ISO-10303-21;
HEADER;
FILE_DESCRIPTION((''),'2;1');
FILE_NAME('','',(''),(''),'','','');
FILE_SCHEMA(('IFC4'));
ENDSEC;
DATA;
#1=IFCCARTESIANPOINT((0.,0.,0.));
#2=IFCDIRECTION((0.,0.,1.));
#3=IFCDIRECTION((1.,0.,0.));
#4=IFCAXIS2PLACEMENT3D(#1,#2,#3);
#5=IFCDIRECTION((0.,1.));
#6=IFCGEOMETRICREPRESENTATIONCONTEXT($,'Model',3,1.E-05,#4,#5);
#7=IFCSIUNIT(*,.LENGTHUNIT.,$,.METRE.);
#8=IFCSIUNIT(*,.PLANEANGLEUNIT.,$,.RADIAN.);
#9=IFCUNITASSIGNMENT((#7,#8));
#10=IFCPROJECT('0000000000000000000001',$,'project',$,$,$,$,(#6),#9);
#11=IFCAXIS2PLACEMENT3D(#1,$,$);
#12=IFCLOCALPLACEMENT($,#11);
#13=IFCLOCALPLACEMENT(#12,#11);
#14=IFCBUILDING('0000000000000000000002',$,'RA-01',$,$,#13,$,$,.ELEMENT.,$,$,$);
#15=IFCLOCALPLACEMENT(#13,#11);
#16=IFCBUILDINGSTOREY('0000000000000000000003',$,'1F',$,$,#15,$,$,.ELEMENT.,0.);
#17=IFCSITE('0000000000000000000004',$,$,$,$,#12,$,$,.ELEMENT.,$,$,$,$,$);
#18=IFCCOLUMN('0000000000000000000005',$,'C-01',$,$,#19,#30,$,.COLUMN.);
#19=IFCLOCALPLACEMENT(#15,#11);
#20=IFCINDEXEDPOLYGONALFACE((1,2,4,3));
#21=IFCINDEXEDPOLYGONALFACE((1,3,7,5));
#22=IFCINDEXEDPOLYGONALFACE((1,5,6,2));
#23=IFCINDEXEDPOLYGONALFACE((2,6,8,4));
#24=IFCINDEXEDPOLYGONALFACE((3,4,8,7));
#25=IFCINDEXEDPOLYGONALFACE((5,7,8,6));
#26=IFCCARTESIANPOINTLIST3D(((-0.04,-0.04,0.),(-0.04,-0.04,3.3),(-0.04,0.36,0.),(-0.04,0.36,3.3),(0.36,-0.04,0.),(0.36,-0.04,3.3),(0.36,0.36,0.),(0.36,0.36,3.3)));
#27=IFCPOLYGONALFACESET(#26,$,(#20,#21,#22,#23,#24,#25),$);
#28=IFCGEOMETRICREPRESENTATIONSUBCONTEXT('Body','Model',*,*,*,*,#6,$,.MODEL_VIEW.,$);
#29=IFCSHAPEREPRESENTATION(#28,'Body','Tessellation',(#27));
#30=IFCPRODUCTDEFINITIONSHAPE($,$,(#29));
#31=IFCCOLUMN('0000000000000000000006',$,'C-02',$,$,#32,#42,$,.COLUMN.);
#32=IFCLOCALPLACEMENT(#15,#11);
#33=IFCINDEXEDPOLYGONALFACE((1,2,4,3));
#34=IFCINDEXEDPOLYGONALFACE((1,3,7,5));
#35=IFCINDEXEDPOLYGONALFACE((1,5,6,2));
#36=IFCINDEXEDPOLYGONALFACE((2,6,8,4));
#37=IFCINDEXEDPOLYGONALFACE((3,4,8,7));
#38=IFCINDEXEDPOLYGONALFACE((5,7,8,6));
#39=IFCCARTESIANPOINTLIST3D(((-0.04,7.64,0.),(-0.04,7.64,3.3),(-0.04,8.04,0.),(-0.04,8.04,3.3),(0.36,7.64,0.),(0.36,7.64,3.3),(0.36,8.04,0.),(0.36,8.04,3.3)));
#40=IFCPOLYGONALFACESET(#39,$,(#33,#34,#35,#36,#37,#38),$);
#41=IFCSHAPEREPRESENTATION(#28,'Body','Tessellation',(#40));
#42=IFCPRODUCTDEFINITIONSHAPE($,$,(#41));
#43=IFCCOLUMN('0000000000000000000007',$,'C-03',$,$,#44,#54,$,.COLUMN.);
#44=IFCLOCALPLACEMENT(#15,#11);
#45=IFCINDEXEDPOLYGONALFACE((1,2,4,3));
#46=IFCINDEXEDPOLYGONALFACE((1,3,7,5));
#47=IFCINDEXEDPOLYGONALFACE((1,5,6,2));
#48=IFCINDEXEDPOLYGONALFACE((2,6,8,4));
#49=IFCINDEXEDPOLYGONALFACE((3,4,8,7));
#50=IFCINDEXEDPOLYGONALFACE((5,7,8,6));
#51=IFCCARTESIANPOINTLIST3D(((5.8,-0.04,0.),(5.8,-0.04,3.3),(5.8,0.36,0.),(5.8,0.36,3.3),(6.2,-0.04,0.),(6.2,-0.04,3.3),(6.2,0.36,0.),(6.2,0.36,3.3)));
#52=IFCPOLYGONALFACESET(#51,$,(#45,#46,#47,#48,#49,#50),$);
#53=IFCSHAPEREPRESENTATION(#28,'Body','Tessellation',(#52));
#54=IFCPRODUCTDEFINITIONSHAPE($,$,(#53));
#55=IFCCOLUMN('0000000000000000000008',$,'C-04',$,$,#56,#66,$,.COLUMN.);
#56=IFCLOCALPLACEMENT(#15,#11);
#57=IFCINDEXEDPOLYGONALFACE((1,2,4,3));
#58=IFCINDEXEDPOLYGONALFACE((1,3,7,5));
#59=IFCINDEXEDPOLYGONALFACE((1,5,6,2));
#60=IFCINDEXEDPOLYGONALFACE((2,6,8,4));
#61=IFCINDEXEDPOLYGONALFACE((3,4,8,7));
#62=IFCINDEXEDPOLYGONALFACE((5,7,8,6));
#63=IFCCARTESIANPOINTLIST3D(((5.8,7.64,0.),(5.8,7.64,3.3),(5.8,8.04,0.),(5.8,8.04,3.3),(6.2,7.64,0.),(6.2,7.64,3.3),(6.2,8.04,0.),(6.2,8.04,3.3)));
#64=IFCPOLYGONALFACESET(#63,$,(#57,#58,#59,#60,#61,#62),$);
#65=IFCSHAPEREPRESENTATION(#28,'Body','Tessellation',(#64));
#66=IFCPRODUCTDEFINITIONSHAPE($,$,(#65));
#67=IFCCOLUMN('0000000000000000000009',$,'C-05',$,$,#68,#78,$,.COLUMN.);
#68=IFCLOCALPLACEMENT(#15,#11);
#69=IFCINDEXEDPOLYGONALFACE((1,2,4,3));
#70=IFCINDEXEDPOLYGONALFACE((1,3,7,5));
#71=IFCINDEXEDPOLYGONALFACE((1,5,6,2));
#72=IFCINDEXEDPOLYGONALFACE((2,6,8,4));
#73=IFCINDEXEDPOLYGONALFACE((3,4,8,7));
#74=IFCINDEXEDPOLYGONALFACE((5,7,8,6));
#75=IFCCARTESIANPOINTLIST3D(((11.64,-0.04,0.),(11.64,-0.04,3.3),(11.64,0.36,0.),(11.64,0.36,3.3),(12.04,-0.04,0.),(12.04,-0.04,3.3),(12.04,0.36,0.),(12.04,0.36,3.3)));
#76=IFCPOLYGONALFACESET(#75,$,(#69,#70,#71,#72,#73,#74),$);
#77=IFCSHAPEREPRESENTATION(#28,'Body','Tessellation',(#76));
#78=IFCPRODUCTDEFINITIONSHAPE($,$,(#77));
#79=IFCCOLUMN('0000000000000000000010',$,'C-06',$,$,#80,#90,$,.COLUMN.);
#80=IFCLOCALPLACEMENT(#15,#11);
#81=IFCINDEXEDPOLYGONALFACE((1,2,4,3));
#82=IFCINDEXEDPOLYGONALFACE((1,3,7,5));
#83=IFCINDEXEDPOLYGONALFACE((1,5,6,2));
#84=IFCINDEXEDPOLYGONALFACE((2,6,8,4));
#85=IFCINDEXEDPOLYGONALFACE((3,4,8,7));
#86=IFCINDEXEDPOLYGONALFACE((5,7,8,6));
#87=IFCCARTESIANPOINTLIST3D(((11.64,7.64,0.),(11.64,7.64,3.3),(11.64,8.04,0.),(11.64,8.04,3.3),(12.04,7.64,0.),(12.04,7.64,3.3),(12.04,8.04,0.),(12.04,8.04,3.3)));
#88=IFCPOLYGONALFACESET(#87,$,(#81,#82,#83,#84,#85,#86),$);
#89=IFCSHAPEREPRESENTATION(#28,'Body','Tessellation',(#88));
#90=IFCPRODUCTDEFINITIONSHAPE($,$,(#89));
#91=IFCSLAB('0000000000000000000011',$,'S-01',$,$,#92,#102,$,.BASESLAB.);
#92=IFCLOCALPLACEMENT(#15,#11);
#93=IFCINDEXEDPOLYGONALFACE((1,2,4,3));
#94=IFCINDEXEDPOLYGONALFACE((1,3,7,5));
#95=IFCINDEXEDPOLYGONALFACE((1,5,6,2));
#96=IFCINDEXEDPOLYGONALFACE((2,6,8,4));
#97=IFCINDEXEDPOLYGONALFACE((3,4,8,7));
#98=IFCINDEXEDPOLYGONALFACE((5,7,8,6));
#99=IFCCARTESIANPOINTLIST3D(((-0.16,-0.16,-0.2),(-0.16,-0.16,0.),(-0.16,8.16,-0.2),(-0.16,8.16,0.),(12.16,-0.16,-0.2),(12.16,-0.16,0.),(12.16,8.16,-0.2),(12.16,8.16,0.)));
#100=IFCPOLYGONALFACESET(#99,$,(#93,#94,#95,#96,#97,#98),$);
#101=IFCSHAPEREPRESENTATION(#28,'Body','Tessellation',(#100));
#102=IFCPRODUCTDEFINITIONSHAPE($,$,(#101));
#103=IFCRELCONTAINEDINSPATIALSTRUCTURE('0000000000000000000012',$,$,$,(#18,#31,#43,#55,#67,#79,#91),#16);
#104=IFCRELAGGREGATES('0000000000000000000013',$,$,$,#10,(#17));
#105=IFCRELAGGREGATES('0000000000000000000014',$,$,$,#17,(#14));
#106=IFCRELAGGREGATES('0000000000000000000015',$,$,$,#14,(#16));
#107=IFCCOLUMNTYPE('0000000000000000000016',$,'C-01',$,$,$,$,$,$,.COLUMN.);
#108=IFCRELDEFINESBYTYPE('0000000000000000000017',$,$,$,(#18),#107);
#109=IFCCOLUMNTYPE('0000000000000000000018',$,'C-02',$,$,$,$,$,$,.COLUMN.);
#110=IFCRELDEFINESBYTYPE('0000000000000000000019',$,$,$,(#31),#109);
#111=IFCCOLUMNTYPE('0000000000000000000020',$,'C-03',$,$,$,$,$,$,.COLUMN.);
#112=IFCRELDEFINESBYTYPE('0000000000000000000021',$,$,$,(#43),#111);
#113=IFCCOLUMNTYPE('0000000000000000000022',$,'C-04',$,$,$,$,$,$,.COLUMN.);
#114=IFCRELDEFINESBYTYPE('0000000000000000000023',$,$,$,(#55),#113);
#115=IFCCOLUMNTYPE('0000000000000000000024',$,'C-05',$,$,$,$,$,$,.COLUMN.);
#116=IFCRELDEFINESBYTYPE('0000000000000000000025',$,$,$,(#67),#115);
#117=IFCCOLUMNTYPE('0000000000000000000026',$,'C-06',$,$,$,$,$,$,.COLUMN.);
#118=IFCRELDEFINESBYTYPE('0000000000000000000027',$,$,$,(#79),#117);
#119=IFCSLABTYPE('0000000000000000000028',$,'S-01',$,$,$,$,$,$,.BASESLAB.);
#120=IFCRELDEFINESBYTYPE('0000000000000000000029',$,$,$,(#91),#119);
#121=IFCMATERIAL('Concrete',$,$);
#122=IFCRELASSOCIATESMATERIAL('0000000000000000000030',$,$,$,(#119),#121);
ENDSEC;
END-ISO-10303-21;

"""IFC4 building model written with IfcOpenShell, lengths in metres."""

from ifc_helpers import new_model, si_unit, direction, frame, origin, origin_with_axes, origin_2d, place, context, subcontext, project, spatial, polyline, rectangle, outline, extrude, material, type_object, element, save


model = new_model("IFC4")

# Units and contexts
model_context = context("Model", 3, precision=1e-05, world=origin_with_axes(), true_north=direction((0.0, 1.0)))
body_context = subcontext(model_context, "Body", "Model", "MODEL_VIEW")
ifc_project = project(units=[si_unit("LENGTHUNIT", "METRE"), si_unit("PLANEANGLEUNIT", "RADIAN")], contexts=[model_context])

# Site, building, storey
site_placement = place(None, origin())
site = spatial("IfcSite", under=ifc_project, at=site_placement, CompositionType="ELEMENT")
building_placement = place(site_placement, origin())
building = spatial("IfcBuilding", under=site, at=building_placement, Name="RA-01", CompositionType="ELEMENT")
storey_placement = place(building_placement, origin())
storey = spatial("IfcBuildingStorey", under=building, at=storey_placement, Name="1F", CompositionType="ELEMENT", Elevation=0.0)

# Columns
column_type_1 = type_object("IfcColumnType", Name="C-01", PredefinedType="COLUMN")
column_1_placement = place(storey_placement, origin())
element("IfcColumn", 1, at=column_1_placement, inside=storey, type_object=column_type_1, Name="C-01", PredefinedType="COLUMN", context=body_context, shape_type="SweptSolid", body=[
    extrude(rectangle(XDim=0.4, YDim=0.4, at=origin_2d()), frame((0.16, 0.16, 0.0)), (0.0, 0.0, 1.0), 3.3),
])
column_type_2 = type_object("IfcColumnType", Name="C-02", PredefinedType="COLUMN")
column_2_placement = place(storey_placement, origin())
element("IfcColumn", 2, at=column_2_placement, inside=storey, type_object=column_type_2, Name="C-02", PredefinedType="COLUMN", context=body_context, shape_type="SweptSolid", body=[
    extrude(rectangle(XDim=0.4, YDim=0.4, at=origin_2d()), frame((0.16, 7.84, 0.0)), (0.0, 0.0, 1.0), 3.3),
])
column_type_3 = type_object("IfcColumnType", Name="C-03", PredefinedType="COLUMN")
column_3_placement = place(storey_placement, origin())
element("IfcColumn", 3, at=column_3_placement, inside=storey, type_object=column_type_3, Name="C-03", PredefinedType="COLUMN", context=body_context, shape_type="SweptSolid", body=[
    extrude(rectangle(XDim=0.4, YDim=0.4, at=origin_2d()), frame((6.0, 0.16, 0.0)), (0.0, 0.0, 1.0), 3.3),
])
column_type_4 = type_object("IfcColumnType", Name="C-04", PredefinedType="COLUMN")
column_4_placement = place(storey_placement, origin())
element("IfcColumn", 4, at=column_4_placement, inside=storey, type_object=column_type_4, Name="C-04", PredefinedType="COLUMN", context=body_context, shape_type="SweptSolid", body=[
    extrude(rectangle(XDim=0.4, YDim=0.4, at=origin_2d()), frame((6.0, 7.84, 0.0)), (0.0, 0.0, 1.0), 3.3),
])
column_type_5 = type_object("IfcColumnType", Name="C-05", PredefinedType="COLUMN")
column_5_placement = place(storey_placement, origin())
element("IfcColumn", 5, at=column_5_placement, inside=storey, type_object=column_type_5, Name="C-05", PredefinedType="COLUMN", context=body_context, shape_type="SweptSolid", body=[
    extrude(rectangle(XDim=0.4, YDim=0.4, at=origin_2d()), frame((11.84, 0.16, 0.0)), (0.0, 0.0, 1.0), 3.3),
])
column_type_6 = type_object("IfcColumnType", Name="C-06", PredefinedType="COLUMN")
column_6_placement = place(storey_placement, origin())
element("IfcColumn", 6, at=column_6_placement, inside=storey, type_object=column_type_6, Name="C-06", PredefinedType="COLUMN", context=body_context, shape_type="SweptSolid", body=[
    extrude(rectangle(XDim=0.4, YDim=0.4, at=origin_2d()), frame((11.84, 7.84, 0.0)), (0.0, 0.0, 1.0), 3.3),
])

# Slab
ifc_material_1 = material(Name="Concrete")
slab_type = type_object("IfcSlabType", Name="S-01", PredefinedType="BASESLAB", material=ifc_material_1)
slab_placement = place(storey_placement, origin())
element("IfcSlab", 7, at=slab_placement, inside=storey, type_object=slab_type, Name="S-01", PredefinedType="BASESLAB", context=body_context, shape_type="SweptSolid", body=[
    extrude(outline(polyline([(-0.16, -0.16), (12.16, -0.16), (12.16, 8.16), (-0.16, 8.16), (-0.16, -0.16)])), frame((0.0, 0.0, -0.2)), (0.0, 0.0, 1.0), 0.2),
])

save(model, "model.ifc")
